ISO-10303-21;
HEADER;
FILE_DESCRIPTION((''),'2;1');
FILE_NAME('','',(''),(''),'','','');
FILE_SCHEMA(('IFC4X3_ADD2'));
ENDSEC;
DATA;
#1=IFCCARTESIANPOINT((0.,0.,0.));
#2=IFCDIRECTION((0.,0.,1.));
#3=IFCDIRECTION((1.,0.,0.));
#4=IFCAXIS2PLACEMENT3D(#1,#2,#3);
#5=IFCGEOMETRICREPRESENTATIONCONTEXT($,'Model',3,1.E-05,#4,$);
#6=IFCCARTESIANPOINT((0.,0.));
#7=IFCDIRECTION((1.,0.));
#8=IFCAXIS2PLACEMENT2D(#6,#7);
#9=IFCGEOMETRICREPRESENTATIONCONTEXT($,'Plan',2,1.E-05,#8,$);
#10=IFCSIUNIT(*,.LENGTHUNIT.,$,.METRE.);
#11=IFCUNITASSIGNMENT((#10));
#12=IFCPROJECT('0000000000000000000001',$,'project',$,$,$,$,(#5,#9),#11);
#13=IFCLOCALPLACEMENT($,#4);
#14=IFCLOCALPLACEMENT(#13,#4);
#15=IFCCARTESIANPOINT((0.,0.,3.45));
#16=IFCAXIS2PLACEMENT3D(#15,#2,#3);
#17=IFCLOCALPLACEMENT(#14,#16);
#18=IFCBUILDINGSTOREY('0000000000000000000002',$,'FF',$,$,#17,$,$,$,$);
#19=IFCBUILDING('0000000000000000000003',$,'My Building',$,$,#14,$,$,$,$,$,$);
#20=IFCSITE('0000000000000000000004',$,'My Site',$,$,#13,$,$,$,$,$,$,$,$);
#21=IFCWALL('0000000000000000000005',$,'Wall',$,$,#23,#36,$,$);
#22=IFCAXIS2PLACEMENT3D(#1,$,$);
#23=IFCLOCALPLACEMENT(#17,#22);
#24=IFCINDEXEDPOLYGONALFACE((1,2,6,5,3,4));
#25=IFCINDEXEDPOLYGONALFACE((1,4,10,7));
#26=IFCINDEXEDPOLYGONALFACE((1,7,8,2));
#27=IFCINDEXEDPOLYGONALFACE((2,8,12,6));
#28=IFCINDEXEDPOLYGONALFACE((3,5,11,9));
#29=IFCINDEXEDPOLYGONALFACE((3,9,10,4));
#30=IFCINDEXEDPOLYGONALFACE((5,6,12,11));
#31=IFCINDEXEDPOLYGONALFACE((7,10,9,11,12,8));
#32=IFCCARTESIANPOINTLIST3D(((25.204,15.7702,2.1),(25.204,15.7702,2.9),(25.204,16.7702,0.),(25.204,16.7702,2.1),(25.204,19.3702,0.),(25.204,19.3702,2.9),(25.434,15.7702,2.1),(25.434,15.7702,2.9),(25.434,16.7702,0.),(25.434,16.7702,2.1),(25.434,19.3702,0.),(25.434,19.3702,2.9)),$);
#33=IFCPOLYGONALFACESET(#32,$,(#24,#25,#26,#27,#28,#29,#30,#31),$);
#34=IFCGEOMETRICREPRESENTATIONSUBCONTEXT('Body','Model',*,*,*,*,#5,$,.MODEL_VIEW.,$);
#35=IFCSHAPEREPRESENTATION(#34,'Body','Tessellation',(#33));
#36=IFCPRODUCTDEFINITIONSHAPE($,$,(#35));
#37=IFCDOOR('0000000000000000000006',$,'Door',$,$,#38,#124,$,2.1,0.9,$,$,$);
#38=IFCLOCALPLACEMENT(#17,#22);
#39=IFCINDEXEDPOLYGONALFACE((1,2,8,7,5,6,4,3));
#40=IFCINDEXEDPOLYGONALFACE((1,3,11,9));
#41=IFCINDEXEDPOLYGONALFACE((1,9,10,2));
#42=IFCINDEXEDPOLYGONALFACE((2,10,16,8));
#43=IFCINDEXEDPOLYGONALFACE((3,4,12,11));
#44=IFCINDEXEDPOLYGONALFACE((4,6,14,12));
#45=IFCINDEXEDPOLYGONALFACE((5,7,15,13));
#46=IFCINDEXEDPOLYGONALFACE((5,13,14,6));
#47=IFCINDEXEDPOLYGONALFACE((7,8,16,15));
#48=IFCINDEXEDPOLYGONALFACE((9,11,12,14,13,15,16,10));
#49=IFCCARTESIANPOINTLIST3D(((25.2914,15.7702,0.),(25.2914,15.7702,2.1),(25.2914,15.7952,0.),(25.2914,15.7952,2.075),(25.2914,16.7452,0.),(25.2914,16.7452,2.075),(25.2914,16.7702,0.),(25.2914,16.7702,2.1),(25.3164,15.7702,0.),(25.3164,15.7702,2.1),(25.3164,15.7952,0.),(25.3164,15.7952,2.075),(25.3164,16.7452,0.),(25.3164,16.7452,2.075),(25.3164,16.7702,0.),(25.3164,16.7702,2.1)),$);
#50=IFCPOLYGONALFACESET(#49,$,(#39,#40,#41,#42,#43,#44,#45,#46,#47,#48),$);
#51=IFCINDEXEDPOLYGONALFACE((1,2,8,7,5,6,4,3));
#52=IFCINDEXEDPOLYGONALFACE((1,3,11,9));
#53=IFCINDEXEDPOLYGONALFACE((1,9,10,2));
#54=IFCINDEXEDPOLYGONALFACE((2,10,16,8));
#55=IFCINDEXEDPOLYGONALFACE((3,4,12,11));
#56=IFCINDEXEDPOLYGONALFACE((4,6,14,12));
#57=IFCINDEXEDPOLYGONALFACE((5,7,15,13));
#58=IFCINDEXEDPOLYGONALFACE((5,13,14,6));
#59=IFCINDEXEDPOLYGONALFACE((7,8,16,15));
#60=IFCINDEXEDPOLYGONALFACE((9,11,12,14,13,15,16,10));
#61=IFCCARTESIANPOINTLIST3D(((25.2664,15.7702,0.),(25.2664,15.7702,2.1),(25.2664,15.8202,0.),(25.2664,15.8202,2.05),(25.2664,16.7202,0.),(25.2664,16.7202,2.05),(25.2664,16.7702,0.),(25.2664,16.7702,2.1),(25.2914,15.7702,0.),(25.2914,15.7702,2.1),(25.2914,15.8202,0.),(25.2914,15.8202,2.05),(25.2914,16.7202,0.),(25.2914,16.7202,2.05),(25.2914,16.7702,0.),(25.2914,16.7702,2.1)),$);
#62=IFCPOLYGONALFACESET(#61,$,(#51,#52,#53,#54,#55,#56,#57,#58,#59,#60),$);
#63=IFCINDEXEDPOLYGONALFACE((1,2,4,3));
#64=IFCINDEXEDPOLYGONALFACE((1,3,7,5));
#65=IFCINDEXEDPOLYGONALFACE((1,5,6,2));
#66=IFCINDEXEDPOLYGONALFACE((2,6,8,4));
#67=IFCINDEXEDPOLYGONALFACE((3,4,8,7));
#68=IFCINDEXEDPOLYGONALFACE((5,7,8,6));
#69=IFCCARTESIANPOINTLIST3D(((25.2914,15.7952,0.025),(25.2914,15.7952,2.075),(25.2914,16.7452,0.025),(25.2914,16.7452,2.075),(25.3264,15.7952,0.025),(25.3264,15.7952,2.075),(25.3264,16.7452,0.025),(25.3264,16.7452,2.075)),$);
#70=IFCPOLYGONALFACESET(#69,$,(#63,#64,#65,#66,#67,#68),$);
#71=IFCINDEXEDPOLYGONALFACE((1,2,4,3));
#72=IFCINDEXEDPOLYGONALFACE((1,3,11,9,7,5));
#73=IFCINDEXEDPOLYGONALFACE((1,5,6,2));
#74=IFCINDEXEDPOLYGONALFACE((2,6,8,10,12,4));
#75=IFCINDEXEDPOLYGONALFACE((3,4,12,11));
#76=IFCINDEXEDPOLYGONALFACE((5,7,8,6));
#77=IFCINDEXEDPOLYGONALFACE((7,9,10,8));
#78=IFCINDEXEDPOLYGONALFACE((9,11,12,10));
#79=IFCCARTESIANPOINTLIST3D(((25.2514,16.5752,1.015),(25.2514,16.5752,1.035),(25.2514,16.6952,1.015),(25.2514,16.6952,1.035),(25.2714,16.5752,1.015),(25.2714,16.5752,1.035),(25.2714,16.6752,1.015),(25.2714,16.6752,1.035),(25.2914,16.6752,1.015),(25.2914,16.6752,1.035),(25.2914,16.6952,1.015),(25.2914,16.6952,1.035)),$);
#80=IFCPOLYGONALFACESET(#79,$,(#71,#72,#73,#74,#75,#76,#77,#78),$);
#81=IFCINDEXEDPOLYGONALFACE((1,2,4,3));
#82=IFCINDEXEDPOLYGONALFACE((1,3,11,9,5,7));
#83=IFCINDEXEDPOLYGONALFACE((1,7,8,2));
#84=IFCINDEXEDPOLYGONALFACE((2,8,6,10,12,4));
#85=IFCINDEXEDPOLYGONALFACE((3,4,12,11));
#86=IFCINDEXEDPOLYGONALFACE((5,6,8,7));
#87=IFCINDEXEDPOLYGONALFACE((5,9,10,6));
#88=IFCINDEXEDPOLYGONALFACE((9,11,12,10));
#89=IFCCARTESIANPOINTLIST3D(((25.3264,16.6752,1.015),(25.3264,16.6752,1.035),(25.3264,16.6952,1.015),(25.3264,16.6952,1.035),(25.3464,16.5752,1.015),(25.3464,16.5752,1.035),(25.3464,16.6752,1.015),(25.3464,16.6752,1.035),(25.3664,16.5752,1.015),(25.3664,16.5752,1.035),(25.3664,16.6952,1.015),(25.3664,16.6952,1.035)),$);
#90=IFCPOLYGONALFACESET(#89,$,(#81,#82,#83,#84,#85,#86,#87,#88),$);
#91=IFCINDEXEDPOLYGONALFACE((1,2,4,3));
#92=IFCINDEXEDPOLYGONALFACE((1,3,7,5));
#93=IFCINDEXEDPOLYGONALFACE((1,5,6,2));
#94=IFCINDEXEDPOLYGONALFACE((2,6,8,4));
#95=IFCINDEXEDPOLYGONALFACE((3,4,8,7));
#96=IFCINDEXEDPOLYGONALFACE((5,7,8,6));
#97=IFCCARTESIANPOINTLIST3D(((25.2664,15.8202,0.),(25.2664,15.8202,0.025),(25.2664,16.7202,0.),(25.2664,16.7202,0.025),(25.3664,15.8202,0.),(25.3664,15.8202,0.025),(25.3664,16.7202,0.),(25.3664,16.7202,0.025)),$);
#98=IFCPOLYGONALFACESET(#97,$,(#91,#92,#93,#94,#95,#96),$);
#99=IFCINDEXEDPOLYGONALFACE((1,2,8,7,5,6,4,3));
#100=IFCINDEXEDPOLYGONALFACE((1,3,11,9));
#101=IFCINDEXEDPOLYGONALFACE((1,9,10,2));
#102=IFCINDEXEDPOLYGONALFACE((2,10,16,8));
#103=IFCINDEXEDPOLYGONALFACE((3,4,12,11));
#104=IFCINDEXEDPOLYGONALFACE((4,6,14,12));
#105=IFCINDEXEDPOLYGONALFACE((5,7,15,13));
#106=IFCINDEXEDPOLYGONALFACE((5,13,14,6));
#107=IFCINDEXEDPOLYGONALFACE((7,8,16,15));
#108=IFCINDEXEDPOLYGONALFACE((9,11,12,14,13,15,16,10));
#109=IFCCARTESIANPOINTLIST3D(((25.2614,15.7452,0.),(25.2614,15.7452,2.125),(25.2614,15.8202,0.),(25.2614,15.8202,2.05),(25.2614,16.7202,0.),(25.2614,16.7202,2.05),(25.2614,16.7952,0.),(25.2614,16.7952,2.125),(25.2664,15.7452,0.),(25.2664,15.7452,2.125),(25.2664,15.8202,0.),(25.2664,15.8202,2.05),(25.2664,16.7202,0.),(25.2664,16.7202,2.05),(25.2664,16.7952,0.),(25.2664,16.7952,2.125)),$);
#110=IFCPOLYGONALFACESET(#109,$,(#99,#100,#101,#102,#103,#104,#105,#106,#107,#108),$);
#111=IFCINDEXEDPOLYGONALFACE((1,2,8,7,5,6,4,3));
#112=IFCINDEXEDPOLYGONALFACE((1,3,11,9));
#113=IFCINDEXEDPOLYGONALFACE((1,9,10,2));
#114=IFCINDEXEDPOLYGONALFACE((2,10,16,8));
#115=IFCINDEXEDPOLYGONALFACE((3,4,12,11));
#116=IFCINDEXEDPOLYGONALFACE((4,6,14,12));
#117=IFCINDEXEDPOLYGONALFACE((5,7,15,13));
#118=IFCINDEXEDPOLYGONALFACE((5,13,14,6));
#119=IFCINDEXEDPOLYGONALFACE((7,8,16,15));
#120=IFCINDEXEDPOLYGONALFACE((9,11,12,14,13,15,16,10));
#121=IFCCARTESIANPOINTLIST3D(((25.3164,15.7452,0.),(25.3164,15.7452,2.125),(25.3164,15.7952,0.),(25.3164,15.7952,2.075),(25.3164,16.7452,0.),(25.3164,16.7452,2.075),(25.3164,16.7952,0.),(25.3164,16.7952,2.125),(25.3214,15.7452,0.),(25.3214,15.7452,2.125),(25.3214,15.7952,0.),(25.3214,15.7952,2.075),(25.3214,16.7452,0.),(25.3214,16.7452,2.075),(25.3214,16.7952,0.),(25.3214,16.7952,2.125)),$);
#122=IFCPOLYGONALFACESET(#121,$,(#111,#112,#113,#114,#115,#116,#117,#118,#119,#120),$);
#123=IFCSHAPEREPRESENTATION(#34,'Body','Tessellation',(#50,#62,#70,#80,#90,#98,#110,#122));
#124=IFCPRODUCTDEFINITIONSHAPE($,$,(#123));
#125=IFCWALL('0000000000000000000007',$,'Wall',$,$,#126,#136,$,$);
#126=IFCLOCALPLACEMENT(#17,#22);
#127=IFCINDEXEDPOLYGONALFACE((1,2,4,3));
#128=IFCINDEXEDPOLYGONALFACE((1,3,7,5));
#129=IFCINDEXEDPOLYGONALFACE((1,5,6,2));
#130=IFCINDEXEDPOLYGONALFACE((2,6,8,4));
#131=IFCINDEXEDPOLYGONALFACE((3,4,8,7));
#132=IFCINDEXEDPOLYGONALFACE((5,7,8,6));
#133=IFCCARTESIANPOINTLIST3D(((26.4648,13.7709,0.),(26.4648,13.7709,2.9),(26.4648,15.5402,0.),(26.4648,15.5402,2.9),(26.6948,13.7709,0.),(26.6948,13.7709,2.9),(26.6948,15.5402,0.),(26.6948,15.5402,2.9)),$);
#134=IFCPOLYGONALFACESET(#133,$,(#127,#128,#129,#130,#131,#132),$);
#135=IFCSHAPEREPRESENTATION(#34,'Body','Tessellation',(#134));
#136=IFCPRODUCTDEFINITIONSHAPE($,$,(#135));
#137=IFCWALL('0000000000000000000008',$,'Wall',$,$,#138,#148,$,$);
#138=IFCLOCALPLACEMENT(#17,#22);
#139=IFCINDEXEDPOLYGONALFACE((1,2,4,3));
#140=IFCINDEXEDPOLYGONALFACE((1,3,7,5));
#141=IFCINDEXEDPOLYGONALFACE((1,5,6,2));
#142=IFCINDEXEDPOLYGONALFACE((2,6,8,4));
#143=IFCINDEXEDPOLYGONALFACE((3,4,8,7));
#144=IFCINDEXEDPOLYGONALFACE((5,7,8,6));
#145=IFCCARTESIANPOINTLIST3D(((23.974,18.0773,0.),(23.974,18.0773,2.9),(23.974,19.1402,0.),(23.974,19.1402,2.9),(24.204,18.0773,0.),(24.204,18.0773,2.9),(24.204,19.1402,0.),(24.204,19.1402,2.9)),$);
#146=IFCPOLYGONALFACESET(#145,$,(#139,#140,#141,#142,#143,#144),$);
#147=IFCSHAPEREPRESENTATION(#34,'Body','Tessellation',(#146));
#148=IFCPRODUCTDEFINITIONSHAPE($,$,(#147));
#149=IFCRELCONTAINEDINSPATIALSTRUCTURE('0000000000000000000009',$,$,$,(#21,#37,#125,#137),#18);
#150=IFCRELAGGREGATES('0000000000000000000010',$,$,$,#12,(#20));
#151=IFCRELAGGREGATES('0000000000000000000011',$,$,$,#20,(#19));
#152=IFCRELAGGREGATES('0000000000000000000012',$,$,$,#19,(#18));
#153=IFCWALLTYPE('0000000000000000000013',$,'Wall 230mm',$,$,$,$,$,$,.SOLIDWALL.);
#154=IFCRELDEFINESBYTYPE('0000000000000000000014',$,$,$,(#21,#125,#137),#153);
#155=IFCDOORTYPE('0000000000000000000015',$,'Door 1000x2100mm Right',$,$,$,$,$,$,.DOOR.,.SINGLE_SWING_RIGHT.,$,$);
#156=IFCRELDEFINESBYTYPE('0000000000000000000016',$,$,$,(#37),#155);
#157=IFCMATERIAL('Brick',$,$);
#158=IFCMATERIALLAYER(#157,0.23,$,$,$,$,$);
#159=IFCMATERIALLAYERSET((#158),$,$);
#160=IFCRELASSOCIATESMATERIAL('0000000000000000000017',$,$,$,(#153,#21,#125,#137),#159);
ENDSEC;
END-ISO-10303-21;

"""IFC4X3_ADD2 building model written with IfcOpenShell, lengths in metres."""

from ifc_helpers import new_model, entity, si_unit, frame, origin_with_axes, origin_2d_with_axis, place, context, subcontext, project, spatial, line, indexed_curve, outline, extrude, shape, source, transform, mapped, material, layer, layer_set, layer_usage, type_object, type_shapes, element, fill, save


model = new_model("IFC4X3_ADD2")

# Units and contexts
model_context = context("Model", 3, precision=1e-05, world=origin_with_axes())
plan_context = context("Plan", 2, precision=1e-05, world=origin_2d_with_axis())
body_context_1 = subcontext(model_context, "Body", "Model", "MODEL_VIEW")
body_context_2 = subcontext(plan_context, "Body", "Plan", "PLAN_VIEW")
ifc_project = project(units=[si_unit("LENGTHUNIT", "METRE")], contexts=[model_context, plan_context])

# Site, building, storey
site_placement = place(None, origin_with_axes())
site = spatial("IfcSite", under=ifc_project, at=site_placement, Name="My Site")
building_placement = place(site_placement, origin_with_axes())
building = spatial("IfcBuilding", under=site, at=building_placement, Name="My Building")
storey_placement = place(building_placement, frame((0.0, 0.0, 3.45), z_axis=(0.0, 0.0, 1.0), x_axis=(1.0, 0.0, 0.0)))
storey = spatial("IfcBuildingStorey", under=building, at=storey_placement, Name="FF")

# Shared definitions
ifc_material = material(Name="Brick")
ifc_layer_1 = layer(ifc_material, 0.23)
ifc_layer_set_1 = layer_set([ifc_layer_1])
wall_type_1 = type_object("IfcWallType", Name="Wall 230mm", PredefinedType="SOLIDWALL", material=ifc_layer_set_1)

# Wall, opening, door
ifc_layer_usage_1 = layer_usage(ifc_layer_set_1, "AXIS2", "POSITIVE", 0.0)
wall_1_placement = place(storey_placement, frame((25.434, 15.7702, 0.0), z_axis=(0.0, 0.0, 1.0), x_axis=(0.000001, 1.0, 0.0)))
wall_1 = element("IfcWall", 1, at=wall_1_placement, inside=storey, type_object=wall_type_1, material=ifc_layer_usage_1, Name="Wall", context=body_context_1, shape_type="SweptSolid", body=[
    extrude(outline(indexed_curve([(0.0, 0.0), (0.0, 0.23), (3.6, 0.23), (3.6, 0.0), (0.0, 0.0)], self_intersect=False)), origin_with_axes(), (0.0, 0.0, 1.0), 2.9),
])
shared_shape_1 = source(origin_with_axes(), body_context_1, "Body", "SweptSolid", [
    extrude(outline(indexed_curve([(0.0, 0.0), (1.0, 0.0), (1.0, 2.1), (0.0, 2.1)], segments=[line(1, 2, 3, 4, 1)])), frame((0.0, -0.6, 0.0), z_axis=(0.0, -1.0, 0.0), x_axis=(1.0, 0.0, 0.0)), (0.0, 0.0, -1.0), 1.2),
])
opening_1_placement = place(wall_1_placement, frame((1.0, 0.1676, 0.0), z_axis=(0.0, 0.0, 1.0), x_axis=(-1.0, 0.0, 0.0)))
opening_1 = element("IfcOpeningElement", 2, at=opening_1_placement, cuts=wall_1, PredefinedType="OPENING", context=body_context_1, shape_type="MappedRepresentation", body=[
    mapped(shared_shape_1, transform((0.0, 0.0, 0.0), x_axis=(1.0, 0.0, 0.0), y_axis=(0.0, 1.0, 0.0), z_axis=(0.0, 0.0, 1.0), scale=1.0)),
])
door_type_1 = type_object("IfcDoorType", Name="Door 1000x2100mm Right", OperationType="SINGLE_SWING_RIGHT", PredefinedType="DOOR")
shared_shape_2 = source(origin_with_axes(), body_context_1, "Body", "SweptSolid", [
    extrude(outline(indexed_curve([(0.0, 0.0), (0.0, 2.1), (1.0, 2.1), (1.0, 0.0), (0.975, 0.0), (0.975, 2.075), (0.025, 2.075), (0.025, 0.0)], segments=[line(1, 2, 3, 4, 5, 6, 7, 8, 1)])), frame((0.0, 0.025, 0.0), z_axis=(0.0, -1.0, 0.0), x_axis=(1.0, 0.0, 0.0)), (0.0, 0.0, -1.0), 0.025),
    extrude(outline(indexed_curve([(0.0, 0.0), (0.0, 2.1), (1.0, 2.1), (1.0, 0.0), (0.95, 0.0), (0.95, 2.05), (0.05, 2.05), (0.05, 0.0)], segments=[line(1, 2, 3, 4, 5, 6, 7, 8, 1)])), frame((0.0, 0.0, 0.0), z_axis=(0.0, -1.0, 0.0), x_axis=(1.0, 0.0, 0.0)), (0.0, 0.0, -1.0), 0.025),
    extrude(outline(indexed_curve([(0.0, 0.0), (0.95, 0.0), (0.95, 0.035), (0.0, 0.035)], segments=[line(1, 2, 3, 4, 1)])), frame((0.025, 0.025, 0.025), z_axis=(0.0, 0.0, 1.0), x_axis=(1.0, 0.0, 0.0)), (0.0, 0.0, 1.0), 2.05),
    extrude(outline(indexed_curve([(0.0, 0.0), (0.0, -0.04), (0.12, -0.04), (0.12, -0.02), (0.02, -0.02), (0.02, 0.0)], segments=[line(1, 2, 3, 4, 5, 6, 1)])), frame((0.075, 0.025, 1.015), z_axis=(0.0, 0.0, 1.0), x_axis=(1.0, 0.0, 0.0)), (0.0, 0.0, 1.0), 0.02),
    extrude(outline(indexed_curve([(0.0, 0.0), (0.0, 0.04), (0.12, 0.04), (0.12, 0.02), (0.02, 0.02), (0.02, 0.0)], segments=[line(1, 2, 3, 4, 5, 6, 1)])), frame((0.075, 0.06, 1.015), z_axis=(0.0, 0.0, 1.0), x_axis=(1.0, 0.0, 0.0)), (0.0, 0.0, 1.0), 0.02),
    extrude(outline(indexed_curve([(0.0, 0.0), (0.9, 0.0), (0.9, 0.1), (0.0, 0.1)], segments=[line(1, 2, 3, 4, 1)])), frame((0.05, 0.0, 0.0), z_axis=(0.0, 0.0, 1.0), x_axis=(1.0, 0.0, 0.0)), (0.0, 0.0, 1.0), 0.025),
    extrude(outline(indexed_curve([(0.0, 0.0), (0.0, 2.125), (1.05, 2.125), (1.05, 0.0), (0.975, 0.0), (0.975, 2.05), (0.075, 2.05), (0.075, 0.0)], segments=[line(1, 2, 3, 4, 5, 6, 7, 8, 1)])), frame((-0.025, -0.005, 0.0), z_axis=(0.0, -1.0, 0.0), x_axis=(1.0, 0.0, 0.0)), (0.0, 0.0, -1.0), 0.005),
    extrude(outline(indexed_curve([(0.0, 0.0), (0.0, 2.125), (1.05, 2.125), (1.05, 0.0), (1.0, 0.0), (1.0, 2.075), (0.05, 2.075), (0.05, 0.0)], segments=[line(1, 2, 3, 4, 5, 6, 7, 8, 1)])), frame((-0.025, 0.05, 0.0), z_axis=(0.0, -1.0, 0.0), x_axis=(1.0, 0.0, 0.0)), (0.0, 0.0, -1.0), 0.005),
])
shared_shape_3 = source(origin_with_axes(), body_context_2, "Body", "Curve2D", [
    entity("IfcIndexedPolyCurve", entity("IfcCartesianPointList2D", [[0.0, 0.0], [0.0, 0.05], [0.025, 0.05], [0.025, 0.025], [0.05, 0.025], [0.05, 0.0]]), [entity("IfcLineIndex", [1, 2, 3, 4, 5, 6, 1])]),
    entity("IfcIndexedPolyCurve", entity("IfcCartesianPointList2D", [[1.0, 0.0], [1.0, 0.05], [0.975, 0.05], [0.975, 0.025], [0.95, 0.025], [0.95, 0.0]]), [entity("IfcLineIndex", [1, 2, 3, 4, 5, 6, 1])]),
    entity("IfcTrimmedCurve", entity("IfcEllipse", entity("IfcAxis2Placement2D", entity("IfcCartesianPoint", [0.94, 0.05]), entity("IfcDirection", [1.0, 0.0])), 0.915, 0.95), [entity("IfcCartesianPoint", [0.94, 1.0])], [entity("IfcCartesianPoint", [0.025, 0.05])], True, "CARTESIAN"),
    entity("IfcIndexedPolyCurve", entity("IfcCartesianPointList2D", [[0.975, 0.05], [0.94, 0.05], [0.94, 1.0], [0.975, 1.0]]), [entity("IfcLineIndex", [1, 2, 3, 4, 1])]),
])
type_shapes(door_type_1, [shared_shape_2, shared_shape_3])
door_1_placement = place(opening_1_placement, origin_with_axes())
door_1 = element("IfcDoor", 3, at=door_1_placement, inside=storey, type_object=door_type_1, Name="Door", OverallHeight=2.1, OverallWidth=0.9, shapes=[
    shape(body_context_1, "Body", "MappedRepresentation", [mapped(shared_shape_2, transform((0.0, 0.0, 0.0), x_axis=(1.0, 0.0, 0.0), y_axis=(0.0, 1.0, 0.0), z_axis=(0.0, 0.0, 1.0), scale=1.0))]),
    shape(body_context_2, "Body", "MappedRepresentation", [mapped(shared_shape_3, transform((0.0, 0.0, 0.0), x_axis=(1.0, 0.0, 0.0), y_axis=(0.0, 1.0, 0.0), z_axis=(0.0, 0.0, 1.0), scale=1.0))]),
])
fill(opening_1, door_1)

# Walls
ifc_layer_usage_2 = layer_usage(ifc_layer_set_1, "AXIS2", "POSITIVE", 0.0)
wall_2_placement = place(storey_placement, frame((26.6948, 13.7709, 0.0), z_axis=(0.0, 0.0, 1.0), x_axis=(0.000001, 1.0, 0.0)))
element("IfcWall", 4, at=wall_2_placement, inside=storey, type_object=wall_type_1, material=ifc_layer_usage_2, Name="Wall", context=body_context_1, shape_type="SweptSolid", body=[
    extrude(outline(indexed_curve([(0.0, 0.0), (0.0, 0.23), (1.7693, 0.23), (1.7693, 0.0), (0.0, 0.0)], self_intersect=False)), origin_with_axes(), (0.0, 0.0, 1.0), 2.9),
])
ifc_layer_usage_3 = layer_usage(ifc_layer_set_1, "AXIS2", "POSITIVE", 0.0)
wall_3_placement = place(storey_placement, frame((24.204, 18.0773, 0.0), z_axis=(0.0, 0.0, 1.0), x_axis=(0.000001, 1.0, 0.0)))
element("IfcWall", 5, at=wall_3_placement, inside=storey, type_object=wall_type_1, material=ifc_layer_usage_3, Name="Wall", context=body_context_1, shape_type="SweptSolid", body=[
    extrude(outline(indexed_curve([(0.0, 0.0), (0.0, 0.23), (1.0629, 0.23), (1.0629, 0.0), (0.0, 0.0)], self_intersect=False)), origin_with_axes(), (0.0, 0.0, 1.0), 2.9),
])

save(model, "model.ifc")
